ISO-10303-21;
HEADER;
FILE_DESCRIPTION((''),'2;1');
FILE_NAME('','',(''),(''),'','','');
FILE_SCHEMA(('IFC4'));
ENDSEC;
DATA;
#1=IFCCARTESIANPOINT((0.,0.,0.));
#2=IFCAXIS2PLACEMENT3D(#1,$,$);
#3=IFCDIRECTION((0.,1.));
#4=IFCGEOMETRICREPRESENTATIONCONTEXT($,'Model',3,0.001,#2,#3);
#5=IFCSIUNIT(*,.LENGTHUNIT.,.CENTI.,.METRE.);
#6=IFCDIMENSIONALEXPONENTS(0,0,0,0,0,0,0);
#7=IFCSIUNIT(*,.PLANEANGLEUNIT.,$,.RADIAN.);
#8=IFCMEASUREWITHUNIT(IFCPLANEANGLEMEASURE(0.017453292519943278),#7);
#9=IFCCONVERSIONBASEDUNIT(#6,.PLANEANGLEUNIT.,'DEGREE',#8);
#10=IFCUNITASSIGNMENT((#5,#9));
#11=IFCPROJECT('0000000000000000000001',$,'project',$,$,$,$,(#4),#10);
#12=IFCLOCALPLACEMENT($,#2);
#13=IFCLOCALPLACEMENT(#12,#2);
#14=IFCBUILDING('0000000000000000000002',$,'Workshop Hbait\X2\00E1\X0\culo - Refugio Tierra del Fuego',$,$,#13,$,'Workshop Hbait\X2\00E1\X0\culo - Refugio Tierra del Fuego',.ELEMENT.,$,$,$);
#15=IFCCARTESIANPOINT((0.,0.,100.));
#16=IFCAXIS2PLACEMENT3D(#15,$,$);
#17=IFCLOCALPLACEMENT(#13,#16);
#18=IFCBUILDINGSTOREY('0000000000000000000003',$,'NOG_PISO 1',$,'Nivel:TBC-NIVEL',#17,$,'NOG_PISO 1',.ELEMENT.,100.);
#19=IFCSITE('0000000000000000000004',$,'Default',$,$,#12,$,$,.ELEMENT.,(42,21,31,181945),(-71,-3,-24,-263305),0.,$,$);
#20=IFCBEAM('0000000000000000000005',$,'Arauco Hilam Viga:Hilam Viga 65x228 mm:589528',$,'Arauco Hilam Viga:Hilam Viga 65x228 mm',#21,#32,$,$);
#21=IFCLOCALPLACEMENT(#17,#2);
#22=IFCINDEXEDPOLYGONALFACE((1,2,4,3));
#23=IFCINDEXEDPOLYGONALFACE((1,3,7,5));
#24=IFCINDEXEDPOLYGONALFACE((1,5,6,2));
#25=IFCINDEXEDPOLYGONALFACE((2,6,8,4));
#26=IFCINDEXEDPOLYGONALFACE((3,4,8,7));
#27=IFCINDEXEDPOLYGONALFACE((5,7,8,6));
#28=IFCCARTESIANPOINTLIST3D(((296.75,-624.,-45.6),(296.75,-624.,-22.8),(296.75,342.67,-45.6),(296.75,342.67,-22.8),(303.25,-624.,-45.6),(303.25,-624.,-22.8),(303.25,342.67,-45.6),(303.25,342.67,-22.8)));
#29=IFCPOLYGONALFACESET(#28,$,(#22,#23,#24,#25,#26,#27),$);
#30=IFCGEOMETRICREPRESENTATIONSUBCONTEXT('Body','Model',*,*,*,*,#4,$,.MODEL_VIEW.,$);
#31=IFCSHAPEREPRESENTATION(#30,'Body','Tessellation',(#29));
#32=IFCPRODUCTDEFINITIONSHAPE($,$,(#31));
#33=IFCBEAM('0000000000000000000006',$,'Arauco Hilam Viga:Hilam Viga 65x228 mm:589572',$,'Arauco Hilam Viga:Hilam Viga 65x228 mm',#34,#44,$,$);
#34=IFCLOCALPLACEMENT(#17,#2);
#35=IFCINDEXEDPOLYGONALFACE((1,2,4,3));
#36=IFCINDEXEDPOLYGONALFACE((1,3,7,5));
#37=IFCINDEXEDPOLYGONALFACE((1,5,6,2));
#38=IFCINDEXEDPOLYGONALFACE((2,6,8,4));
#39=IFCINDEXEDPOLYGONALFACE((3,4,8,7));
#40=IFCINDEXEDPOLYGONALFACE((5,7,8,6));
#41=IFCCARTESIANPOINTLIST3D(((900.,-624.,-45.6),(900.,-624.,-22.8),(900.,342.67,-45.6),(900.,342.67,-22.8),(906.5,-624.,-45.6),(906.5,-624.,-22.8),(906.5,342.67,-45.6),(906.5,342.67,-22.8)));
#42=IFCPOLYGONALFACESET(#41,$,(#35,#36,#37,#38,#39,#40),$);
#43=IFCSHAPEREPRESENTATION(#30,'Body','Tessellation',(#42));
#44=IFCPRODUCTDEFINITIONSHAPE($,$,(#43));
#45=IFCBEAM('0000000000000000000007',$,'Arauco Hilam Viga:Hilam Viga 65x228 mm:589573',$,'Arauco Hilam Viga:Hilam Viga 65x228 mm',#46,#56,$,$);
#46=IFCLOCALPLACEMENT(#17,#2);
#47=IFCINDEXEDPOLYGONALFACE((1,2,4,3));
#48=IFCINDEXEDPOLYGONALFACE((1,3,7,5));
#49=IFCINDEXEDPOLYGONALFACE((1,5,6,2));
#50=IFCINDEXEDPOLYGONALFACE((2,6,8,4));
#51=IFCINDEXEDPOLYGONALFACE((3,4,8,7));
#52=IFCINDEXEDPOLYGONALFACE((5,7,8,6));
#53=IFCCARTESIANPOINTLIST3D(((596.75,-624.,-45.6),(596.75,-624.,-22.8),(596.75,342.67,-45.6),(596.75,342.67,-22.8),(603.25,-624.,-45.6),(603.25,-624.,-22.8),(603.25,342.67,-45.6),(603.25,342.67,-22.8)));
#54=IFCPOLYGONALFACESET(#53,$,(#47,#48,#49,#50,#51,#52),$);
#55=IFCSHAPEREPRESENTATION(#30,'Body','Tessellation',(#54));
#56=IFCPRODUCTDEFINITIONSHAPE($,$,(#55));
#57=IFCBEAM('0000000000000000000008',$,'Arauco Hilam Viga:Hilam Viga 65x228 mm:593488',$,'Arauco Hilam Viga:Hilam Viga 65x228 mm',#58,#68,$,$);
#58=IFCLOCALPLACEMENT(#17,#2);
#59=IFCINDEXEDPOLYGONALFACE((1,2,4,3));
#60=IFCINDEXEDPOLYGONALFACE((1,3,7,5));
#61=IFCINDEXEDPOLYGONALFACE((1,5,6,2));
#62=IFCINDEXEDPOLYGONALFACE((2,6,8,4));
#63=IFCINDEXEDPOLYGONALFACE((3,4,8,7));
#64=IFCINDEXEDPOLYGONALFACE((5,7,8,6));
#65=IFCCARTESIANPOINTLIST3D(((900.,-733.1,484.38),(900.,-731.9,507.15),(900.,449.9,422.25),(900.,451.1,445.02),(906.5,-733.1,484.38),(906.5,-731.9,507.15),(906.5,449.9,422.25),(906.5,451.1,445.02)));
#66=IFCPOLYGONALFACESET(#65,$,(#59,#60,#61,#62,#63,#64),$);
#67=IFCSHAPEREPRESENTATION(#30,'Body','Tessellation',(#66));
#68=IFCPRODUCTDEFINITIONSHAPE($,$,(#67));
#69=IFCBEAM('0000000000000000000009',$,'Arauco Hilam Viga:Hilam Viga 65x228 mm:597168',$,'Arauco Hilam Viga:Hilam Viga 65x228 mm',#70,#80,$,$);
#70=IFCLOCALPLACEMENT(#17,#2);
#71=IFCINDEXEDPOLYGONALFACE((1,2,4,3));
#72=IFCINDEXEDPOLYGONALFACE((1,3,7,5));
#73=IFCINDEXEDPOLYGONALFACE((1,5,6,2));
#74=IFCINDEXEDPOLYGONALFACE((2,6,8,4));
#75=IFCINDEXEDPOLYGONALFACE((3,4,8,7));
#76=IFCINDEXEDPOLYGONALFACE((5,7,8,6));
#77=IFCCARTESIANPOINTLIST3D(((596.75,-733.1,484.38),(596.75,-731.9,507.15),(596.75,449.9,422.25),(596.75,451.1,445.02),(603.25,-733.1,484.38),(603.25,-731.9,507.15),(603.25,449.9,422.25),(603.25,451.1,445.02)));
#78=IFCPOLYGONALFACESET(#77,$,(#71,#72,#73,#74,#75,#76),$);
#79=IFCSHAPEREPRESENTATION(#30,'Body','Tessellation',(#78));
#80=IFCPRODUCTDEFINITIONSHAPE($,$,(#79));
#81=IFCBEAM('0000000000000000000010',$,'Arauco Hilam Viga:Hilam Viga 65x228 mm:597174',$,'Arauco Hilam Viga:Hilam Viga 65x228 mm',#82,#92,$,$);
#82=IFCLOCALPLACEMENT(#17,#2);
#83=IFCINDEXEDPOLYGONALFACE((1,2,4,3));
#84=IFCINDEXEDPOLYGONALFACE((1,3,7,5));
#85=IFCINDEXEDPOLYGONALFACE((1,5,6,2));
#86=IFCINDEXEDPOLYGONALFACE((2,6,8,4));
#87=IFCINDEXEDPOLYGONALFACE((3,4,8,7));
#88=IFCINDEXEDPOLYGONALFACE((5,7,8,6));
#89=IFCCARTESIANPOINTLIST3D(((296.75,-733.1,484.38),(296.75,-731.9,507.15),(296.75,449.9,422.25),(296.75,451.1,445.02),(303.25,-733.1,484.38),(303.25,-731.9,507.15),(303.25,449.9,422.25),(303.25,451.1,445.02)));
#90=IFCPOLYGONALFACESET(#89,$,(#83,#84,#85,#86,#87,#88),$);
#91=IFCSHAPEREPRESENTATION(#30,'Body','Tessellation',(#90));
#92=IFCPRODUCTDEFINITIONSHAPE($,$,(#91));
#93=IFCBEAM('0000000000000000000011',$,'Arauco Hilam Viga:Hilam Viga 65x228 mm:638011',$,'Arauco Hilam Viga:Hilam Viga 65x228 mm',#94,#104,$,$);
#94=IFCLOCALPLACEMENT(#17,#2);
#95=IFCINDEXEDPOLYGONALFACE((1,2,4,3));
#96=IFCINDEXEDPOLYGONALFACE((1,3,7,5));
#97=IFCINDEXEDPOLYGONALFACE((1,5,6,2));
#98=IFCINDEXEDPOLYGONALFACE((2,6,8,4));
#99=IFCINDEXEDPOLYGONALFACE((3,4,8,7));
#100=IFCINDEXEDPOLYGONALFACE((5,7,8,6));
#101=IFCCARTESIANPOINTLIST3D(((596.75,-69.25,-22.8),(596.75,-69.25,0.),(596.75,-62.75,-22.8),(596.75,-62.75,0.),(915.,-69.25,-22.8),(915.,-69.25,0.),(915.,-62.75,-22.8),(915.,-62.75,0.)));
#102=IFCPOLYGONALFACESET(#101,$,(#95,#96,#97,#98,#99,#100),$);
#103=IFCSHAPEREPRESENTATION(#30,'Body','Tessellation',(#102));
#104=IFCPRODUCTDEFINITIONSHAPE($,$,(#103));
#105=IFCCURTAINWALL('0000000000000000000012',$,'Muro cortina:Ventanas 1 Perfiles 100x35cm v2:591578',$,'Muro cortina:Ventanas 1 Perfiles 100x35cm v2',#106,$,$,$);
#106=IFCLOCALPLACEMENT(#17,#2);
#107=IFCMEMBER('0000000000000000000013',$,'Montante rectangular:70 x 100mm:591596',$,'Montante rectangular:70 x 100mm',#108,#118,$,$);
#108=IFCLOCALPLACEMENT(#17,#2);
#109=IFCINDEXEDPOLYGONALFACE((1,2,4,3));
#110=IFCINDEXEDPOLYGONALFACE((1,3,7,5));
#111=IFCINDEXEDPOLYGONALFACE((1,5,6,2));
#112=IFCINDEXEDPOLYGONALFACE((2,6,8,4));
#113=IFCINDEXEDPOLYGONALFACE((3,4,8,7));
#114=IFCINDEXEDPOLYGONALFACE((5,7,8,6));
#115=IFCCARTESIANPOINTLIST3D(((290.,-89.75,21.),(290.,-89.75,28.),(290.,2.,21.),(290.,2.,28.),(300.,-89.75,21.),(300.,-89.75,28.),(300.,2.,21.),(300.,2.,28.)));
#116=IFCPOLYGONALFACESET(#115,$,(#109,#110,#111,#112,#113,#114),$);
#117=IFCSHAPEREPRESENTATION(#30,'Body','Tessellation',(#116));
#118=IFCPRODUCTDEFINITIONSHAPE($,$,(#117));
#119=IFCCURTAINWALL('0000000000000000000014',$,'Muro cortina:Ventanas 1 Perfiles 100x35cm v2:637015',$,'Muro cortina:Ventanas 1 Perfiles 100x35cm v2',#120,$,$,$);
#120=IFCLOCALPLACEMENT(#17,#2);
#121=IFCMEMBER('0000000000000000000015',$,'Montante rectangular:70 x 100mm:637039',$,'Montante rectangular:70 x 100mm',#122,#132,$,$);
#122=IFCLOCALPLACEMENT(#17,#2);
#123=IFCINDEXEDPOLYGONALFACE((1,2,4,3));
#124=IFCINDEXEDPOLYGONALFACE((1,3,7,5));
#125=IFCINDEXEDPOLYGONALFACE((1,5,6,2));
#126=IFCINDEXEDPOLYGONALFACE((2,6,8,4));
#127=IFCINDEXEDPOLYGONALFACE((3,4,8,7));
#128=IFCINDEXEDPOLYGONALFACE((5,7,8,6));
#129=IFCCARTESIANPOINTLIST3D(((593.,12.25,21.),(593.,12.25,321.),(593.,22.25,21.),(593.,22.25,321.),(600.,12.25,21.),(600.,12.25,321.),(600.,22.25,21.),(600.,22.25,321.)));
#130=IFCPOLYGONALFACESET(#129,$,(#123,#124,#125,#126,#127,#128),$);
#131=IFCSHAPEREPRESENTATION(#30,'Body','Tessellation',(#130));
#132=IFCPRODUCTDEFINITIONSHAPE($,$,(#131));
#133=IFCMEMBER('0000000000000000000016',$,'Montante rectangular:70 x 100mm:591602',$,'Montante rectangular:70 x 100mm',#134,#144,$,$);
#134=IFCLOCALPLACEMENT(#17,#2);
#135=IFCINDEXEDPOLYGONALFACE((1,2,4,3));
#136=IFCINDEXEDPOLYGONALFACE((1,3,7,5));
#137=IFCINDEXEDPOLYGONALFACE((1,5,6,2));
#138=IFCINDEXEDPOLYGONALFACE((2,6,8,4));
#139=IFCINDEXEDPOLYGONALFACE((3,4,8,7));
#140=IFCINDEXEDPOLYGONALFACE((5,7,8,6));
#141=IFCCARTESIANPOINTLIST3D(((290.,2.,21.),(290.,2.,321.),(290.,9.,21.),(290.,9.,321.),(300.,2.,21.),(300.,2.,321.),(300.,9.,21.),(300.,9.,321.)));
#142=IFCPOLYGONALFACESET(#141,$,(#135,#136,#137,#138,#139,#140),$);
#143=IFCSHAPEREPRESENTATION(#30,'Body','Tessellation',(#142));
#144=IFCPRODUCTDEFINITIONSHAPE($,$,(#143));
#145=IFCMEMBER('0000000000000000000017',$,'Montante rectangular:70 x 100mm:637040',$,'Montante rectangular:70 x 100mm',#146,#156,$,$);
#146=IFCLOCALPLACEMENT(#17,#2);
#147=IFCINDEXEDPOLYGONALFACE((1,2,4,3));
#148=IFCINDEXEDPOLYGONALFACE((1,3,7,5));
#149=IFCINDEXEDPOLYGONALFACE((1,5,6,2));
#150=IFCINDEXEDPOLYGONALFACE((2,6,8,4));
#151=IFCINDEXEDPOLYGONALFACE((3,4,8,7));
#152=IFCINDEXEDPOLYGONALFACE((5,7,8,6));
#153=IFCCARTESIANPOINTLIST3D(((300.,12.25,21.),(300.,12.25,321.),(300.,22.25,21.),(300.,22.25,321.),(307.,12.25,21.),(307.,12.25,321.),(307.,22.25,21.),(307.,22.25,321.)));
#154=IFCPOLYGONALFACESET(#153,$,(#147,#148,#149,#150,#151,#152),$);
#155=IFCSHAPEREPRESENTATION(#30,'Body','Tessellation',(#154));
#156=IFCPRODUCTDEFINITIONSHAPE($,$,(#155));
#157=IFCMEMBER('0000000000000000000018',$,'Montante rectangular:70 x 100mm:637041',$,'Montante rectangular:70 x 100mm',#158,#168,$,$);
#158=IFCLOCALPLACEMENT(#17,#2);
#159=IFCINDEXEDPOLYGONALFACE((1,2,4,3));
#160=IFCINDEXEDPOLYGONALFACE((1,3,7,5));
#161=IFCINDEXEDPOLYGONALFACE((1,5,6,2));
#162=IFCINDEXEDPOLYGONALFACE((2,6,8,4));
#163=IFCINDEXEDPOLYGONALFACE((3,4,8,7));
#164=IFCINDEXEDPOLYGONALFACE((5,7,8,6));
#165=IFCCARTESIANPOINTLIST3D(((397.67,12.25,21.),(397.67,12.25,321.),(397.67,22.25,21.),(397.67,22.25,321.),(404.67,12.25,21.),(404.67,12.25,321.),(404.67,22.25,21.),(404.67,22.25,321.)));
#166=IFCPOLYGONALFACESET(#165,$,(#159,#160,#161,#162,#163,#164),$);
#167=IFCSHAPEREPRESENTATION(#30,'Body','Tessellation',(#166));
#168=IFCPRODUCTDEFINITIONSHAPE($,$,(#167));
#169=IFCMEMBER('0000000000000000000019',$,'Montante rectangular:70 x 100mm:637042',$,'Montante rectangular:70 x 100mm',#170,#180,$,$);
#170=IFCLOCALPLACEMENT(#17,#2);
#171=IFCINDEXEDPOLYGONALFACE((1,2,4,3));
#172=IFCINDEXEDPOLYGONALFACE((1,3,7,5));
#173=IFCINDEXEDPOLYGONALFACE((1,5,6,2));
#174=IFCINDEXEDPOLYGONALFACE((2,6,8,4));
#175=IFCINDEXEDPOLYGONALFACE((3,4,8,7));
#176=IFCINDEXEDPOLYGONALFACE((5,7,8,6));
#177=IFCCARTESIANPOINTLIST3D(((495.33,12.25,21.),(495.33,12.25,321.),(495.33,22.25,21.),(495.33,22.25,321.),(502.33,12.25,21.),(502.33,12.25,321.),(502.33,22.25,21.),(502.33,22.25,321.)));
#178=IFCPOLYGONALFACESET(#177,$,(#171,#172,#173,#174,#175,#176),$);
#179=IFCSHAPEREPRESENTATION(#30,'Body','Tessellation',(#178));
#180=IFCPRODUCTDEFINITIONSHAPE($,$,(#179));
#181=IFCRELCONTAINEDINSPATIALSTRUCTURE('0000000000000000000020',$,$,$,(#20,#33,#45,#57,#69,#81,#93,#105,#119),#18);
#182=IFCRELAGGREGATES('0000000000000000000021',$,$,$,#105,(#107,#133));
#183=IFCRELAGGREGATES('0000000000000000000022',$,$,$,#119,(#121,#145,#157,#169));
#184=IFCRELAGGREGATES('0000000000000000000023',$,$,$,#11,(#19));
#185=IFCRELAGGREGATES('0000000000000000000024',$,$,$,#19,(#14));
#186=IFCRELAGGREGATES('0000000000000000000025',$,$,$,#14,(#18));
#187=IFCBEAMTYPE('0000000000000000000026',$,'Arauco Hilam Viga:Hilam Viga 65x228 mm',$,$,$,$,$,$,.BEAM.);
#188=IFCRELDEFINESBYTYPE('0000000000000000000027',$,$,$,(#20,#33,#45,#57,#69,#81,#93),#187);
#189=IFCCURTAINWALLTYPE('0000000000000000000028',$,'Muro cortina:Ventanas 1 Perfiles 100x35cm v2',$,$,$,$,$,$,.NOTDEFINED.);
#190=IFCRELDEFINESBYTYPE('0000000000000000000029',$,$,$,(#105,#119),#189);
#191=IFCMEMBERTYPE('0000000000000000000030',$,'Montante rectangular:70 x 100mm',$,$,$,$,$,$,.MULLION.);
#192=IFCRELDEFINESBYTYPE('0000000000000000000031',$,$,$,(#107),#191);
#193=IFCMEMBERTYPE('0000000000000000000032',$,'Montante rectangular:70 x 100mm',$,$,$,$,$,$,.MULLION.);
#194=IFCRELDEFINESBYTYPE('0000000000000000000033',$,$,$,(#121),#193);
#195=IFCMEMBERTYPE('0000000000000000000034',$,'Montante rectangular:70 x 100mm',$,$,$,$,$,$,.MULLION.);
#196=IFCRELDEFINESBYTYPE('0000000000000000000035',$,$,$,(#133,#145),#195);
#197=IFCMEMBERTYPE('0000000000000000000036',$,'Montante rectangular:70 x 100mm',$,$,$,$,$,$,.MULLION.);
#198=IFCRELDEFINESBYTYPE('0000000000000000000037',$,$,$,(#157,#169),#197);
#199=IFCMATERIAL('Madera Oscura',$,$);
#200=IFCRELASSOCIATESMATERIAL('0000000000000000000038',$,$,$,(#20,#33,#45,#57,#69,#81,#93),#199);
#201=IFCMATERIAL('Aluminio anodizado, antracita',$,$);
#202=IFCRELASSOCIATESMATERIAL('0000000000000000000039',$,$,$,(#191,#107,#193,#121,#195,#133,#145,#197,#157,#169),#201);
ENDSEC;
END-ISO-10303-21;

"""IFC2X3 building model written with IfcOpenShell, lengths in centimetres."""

from ifc_helpers import new_model, entity, si_unit, converted_unit, direction, frame, frame_2d, origin, origin_2d_with_axis, place, context, subcontext, project, spatial, rectangle, extrude, source, transform, mapped, material, type_object, type_shapes, element, aggregate, save


model = new_model("IFC2X3")

# Units and contexts
model_context = context("Model", 3, precision=0.001, world=origin(), true_north=direction((0.0, 1.0)))
body_context = subcontext(model_context, "Body", "Model", "MODEL_VIEW")
ifc_project = project(units=[si_unit("LENGTHUNIT", "METRE", prefix="CENTI"), converted_unit("PLANEANGLEUNIT", "DEGREE", entity("IfcPlaneAngleMeasure", 0.017453292519943278), si_unit("PLANEANGLEUNIT", "RADIAN"), dimensions=[0, 0, 0, 0, 0, 0, 0])], contexts=[model_context])

# Site, building, storey
site_placement = place(None, origin())
site = spatial("IfcSite", under=ifc_project, at=site_placement, Name="Default", CompositionType="ELEMENT", RefLatitude=(42, 21, 31, 181945), RefLongitude=(-71, -3, -24, -263305), RefElevation=0.0)
building_placement = place(site_placement, origin())
building = spatial("IfcBuilding", under=site, at=building_placement, Name="Workshop Hbaitáculo - Refugio Tierra del Fuego", LongName="Workshop Hbaitáculo - Refugio Tierra del Fuego", CompositionType="ELEMENT")
storey_placement = place(building_placement, frame((0.0, 0.0, 100.0)))
storey = spatial("IfcBuildingStorey", under=building, at=storey_placement, Name="NOG_PISO 1", ObjectType="Nivel:TBC-NIVEL", LongName="NOG_PISO 1", CompositionType="ELEMENT", Elevation=100.0)

# Beams
ifc_material_1 = material(Name="Madera Oscura")
beam_type = type_object("IfcBeamType", Name="Arauco Hilam Viga:Hilam Viga 65x228 mm", PredefinedType="BEAM")
beam_1_placement = place(storey_placement, frame((300.0, 318.11, -22.8), z_axis=(0.0, 0.0, 1.0), x_axis=(0.0, -1.0, 0.0)))
element("IfcBeam", 1, at=beam_1_placement, inside=storey, type_object=beam_type, material=ifc_material_1, Name="Arauco Hilam Viga:Hilam Viga 65x228 mm:589528", ObjectType="Arauco Hilam Viga:Hilam Viga 65x228 mm", context=body_context, shape_type="SweptSolid", body=[
    extrude(rectangle(XDim=22.8, YDim=6.5, at=frame_2d((0.0, 0.0), x_axis=(1.0, 0.0))), frame((-24.56, 0.0, -11.4), z_axis=(1.0, 0.0, 0.0), x_axis=(0.0, 0.0, -1.0)), (0.0, 0.0, 1.0), 966.67),
])
for number, where, z_axis, x_axis, name in (
    (2, (903.25, 318.11, -22.8), (0.0, 0.0, 1.0), (0.0, -1.0, 0.0), "Arauco Hilam Viga:Hilam Viga 65x228 mm:589572"),
    (3, (600.0, 318.11, -22.8), (0.0, 0.0, 1.0), (0.0, -1.0, 0.0), "Arauco Hilam Viga:Hilam Viga 65x228 mm:589573"),
):
    element("IfcBeam", number, at=place(storey_placement, frame(where, z_axis=z_axis, x_axis=x_axis)), inside=storey, type_object=beam_type, material=ifc_material_1, Name=name, ObjectType="Arauco Hilam Viga:Hilam Viga 65x228 mm", context=body_context, shape_type="SweptSolid", body=[
        extrude(rectangle(XDim=22.8, YDim=6.5, at=frame_2d((0.0, 0.0), x_axis=(1.0, 0.0))), frame((-24.56, 0.0, -11.4), z_axis=(1.0, 0.0, 0.0), x_axis=(0.0, 0.0, -1.0)), (0.0, 0.0, 1.0), 966.67),
    ])
beam_2_placement = place(storey_placement, frame((903.25, 318.11, 452.0), z_axis=(0.0, 0.052449, 0.998624), x_axis=(0.0, -0.998624, 0.052449)))
element("IfcBeam", 4, at=beam_2_placement, inside=storey, type_object=beam_type, material=ifc_material_1, Name="Arauco Hilam Viga:Hilam Viga 65x228 mm:593488", ObjectType="Arauco Hilam Viga:Hilam Viga 65x228 mm", context=body_context, shape_type="SweptSolid", body=[
    extrude(rectangle(XDim=22.8, YDim=6.5, at=origin_2d_with_axis()), frame((-133.18, 0.0, -11.4), z_axis=(1.0, 0.0, 0.0), x_axis=(0.0, 0.0, -1.0)), (0.0, 0.0, 1.0), 1184.63),
])
beam_3_placement = place(storey_placement, frame((600.0, 318.11, 452.0), z_axis=(0.0, 0.052449, 0.998624), x_axis=(0.0, -0.998624, 0.052449)))
element("IfcBeam", 5, at=beam_3_placement, inside=storey, type_object=beam_type, material=ifc_material_1, Name="Arauco Hilam Viga:Hilam Viga 65x228 mm:597168", ObjectType="Arauco Hilam Viga:Hilam Viga 65x228 mm", context=body_context, shape_type="SweptSolid", body=[
    extrude(rectangle(XDim=22.8, YDim=6.5, at=origin_2d_with_axis()), frame((-133.18, 0.0, -11.4), z_axis=(1.0, 0.0, 0.0), x_axis=(0.0, 0.0, -1.0)), (0.0, 0.0, 1.0), 1184.63),
])
beam_4_placement = place(storey_placement, frame((300.0, 318.11, 452.0), z_axis=(0.0, 0.052449, 0.998624), x_axis=(0.0, -0.998624, 0.052449)))
element("IfcBeam", 6, at=beam_4_placement, inside=storey, type_object=beam_type, material=ifc_material_1, Name="Arauco Hilam Viga:Hilam Viga 65x228 mm:597174", ObjectType="Arauco Hilam Viga:Hilam Viga 65x228 mm", context=body_context, shape_type="SweptSolid", body=[
    extrude(rectangle(XDim=22.8, YDim=6.5, at=frame_2d((0.0, 0.0), x_axis=(1.0, 0.0))), frame((-133.18, 0.0, -11.4), z_axis=(1.0, 0.0, 0.0), x_axis=(0.0, 0.0, -1.0)), (0.0, 0.0, 1.0), 1184.63),
])
beam_5_placement = place(storey_placement, frame((596.75, -66.0, 0.0)))
element("IfcBeam", 7, at=beam_5_placement, inside=storey, type_object=beam_type, material=ifc_material_1, Name="Arauco Hilam Viga:Hilam Viga 65x228 mm:638011", ObjectType="Arauco Hilam Viga:Hilam Viga 65x228 mm", context=body_context, shape_type="SweptSolid", body=[
    extrude(rectangle(XDim=22.8, YDim=6.5, at=frame_2d((0.0, 0.0), x_axis=(1.0, 0.0))), frame((0.0, 0.0, -11.4), z_axis=(1.0, 0.0, 0.0), x_axis=(0.0, 0.0, -1.0)), (0.0, 0.0, 1.0), 318.25),
])

# Curtain walls, members
curtain_wall_type = type_object("IfcCurtainWallType", Name="Muro cortina:Ventanas 1 Perfiles 100x35cm v2", PredefinedType="NOTDEFINED")
curtain_wall_1_placement = place(storey_placement, frame((0.0, 0.0, -100.0)))
curtain_wall_1 = element("IfcCurtainWall", 8, at=curtain_wall_1_placement, inside=storey, type_object=curtain_wall_type, Name="Muro cortina:Ventanas 1 Perfiles 100x35cm v2:591578", ObjectType="Muro cortina:Ventanas 1 Perfiles 100x35cm v2")
ifc_material_2 = material(Name="Aluminio anodizado, antracita")
member_type_1 = type_object("IfcMemberType", Name="Montante rectangular:70 x 100mm", PredefinedType="MULLION", material=ifc_material_2)
shared_shape_1 = source(origin(), body_context, "Body", "SweptSolid", [
    extrude(rectangle(XDim=7.0, YDim=10.0, at=origin_2d_with_axis()), frame((-3.5, 0.0, -91.75), z_axis=(0.0, 0.0, 1.0), x_axis=(-1.0, 0.0, 0.0)), (0.0, 0.0, 1.0), 91.75),
])
type_shapes(member_type_1, [shared_shape_1])
member_1_placement = place(curtain_wall_1_placement, frame((295.0, 2.0, 121.0), z_axis=(0.0, 1.0, 0.0), x_axis=(0.0, 0.0, -1.0)))
member_1 = element("IfcMember", 9, at=member_1_placement, type_object=member_type_1, material=ifc_material_2, Name="Montante rectangular:70 x 100mm:591596", ObjectType="Montante rectangular:70 x 100mm", context=body_context, shape_type="MappedRepresentation", body=[
    mapped(shared_shape_1, transform((0.0, 0.0, 0.0), scale=1.0)),
])
curtain_wall_2_placement = place(storey_placement, frame((0.0, 0.0, -100.0)))
curtain_wall_2 = element("IfcCurtainWall", 10, at=curtain_wall_2_placement, inside=storey, type_object=curtain_wall_type, Name="Muro cortina:Ventanas 1 Perfiles 100x35cm v2:637015", ObjectType="Muro cortina:Ventanas 1 Perfiles 100x35cm v2")
member_type_2 = type_object("IfcMemberType", Name="Montante rectangular:70 x 100mm", PredefinedType="MULLION", material=ifc_material_2)
shared_shape_2 = source(origin(), body_context, "Body", "SweptSolid", [
    extrude(rectangle(XDim=7.0, YDim=10.0, at=origin_2d_with_axis()), frame((-3.5, 0.0, -300.0), z_axis=(0.0, 0.0, 1.0), x_axis=(-1.0, 0.0, 0.0)), (0.0, 0.0, 1.0), 300.0),
])
type_shapes(member_type_2, [shared_shape_2])
member_2_placement = place(curtain_wall_2_placement, frame((600.0, 17.25, 121.0), z_axis=(0.0, 0.0, -1.0), x_axis=(1.0, 0.0, 0.0)))
member_2 = element("IfcMember", 11, at=member_2_placement, type_object=member_type_2, material=ifc_material_2, Name="Montante rectangular:70 x 100mm:637039", ObjectType="Montante rectangular:70 x 100mm", context=body_context, shape_type="MappedRepresentation", body=[
    mapped(shared_shape_2, transform((0.0, 0.0, 0.0), scale=1.0)),
])

# Members
member_type_3 = type_object("IfcMemberType", Name="Montante rectangular:70 x 100mm", PredefinedType="MULLION", material=ifc_material_2)
shared_shape_3 = source(origin(), body_context, "Body", "SweptSolid", [
    extrude(rectangle(XDim=7.0, YDim=10.0, at=origin_2d_with_axis()), frame((-3.5, 0.0, -300.0), z_axis=(0.0, 0.0, 1.0), x_axis=(-1.0, 0.0, 0.0)), (0.0, 0.0, 1.0), 300.0),
])
type_shapes(member_type_3, [shared_shape_3])
member_3_placement = place(curtain_wall_1_placement, frame((295.0, 9.0, 421.0), z_axis=(0.0, 0.0, 1.0), x_axis=(0.0, 1.0, 0.0)))
member_3 = element("IfcMember", 12, at=member_3_placement, type_object=member_type_3, material=ifc_material_2, Name="Montante rectangular:70 x 100mm:591602", ObjectType="Montante rectangular:70 x 100mm", context=body_context, shape_type="MappedRepresentation", body=[
    mapped(shared_shape_3, transform((0.0, 0.0, 0.0), scale=1.0)),
])
member_4_placement = place(curtain_wall_2_placement, frame((300.0, 17.25, 421.0), z_axis=(0.0, 0.0, 1.0), x_axis=(-1.0, 0.0, 0.0)))
member_4 = element("IfcMember", 13, at=member_4_placement, type_object=member_type_3, material=ifc_material_2, Name="Montante rectangular:70 x 100mm:637040", ObjectType="Montante rectangular:70 x 100mm", context=body_context, shape_type="MappedRepresentation", body=[
    mapped(shared_shape_3, transform((0.0, 0.0, 0.0), scale=1.0)),
])
member_type_4 = type_object("IfcMemberType", Name="Montante rectangular:70 x 100mm", PredefinedType="MULLION", material=ifc_material_2)
shared_shape_4 = source(origin(), body_context, "Body", "SweptSolid", [
    extrude(rectangle(XDim=7.0, YDim=10.0, at=frame_2d((0.0, 0.0), x_axis=(1.0, 0.0))), frame((0.0, 0.0, -300.0), z_axis=(0.0, 0.0, 1.0), x_axis=(-1.0, 0.0, 0.0)), (0.0, 0.0, 1.0), 300.0),
])
type_shapes(member_type_4, [shared_shape_4])
member_5_placement = place(curtain_wall_2_placement, frame((401.17, 17.25, 121.0), z_axis=(0.0, 0.0, -1.0), x_axis=(1.0, 0.0, 0.0)))
member_5 = element("IfcMember", 14, at=member_5_placement, type_object=member_type_4, material=ifc_material_2, Name="Montante rectangular:70 x 100mm:637041", ObjectType="Montante rectangular:70 x 100mm", context=body_context, shape_type="MappedRepresentation", body=[
    mapped(shared_shape_4, transform((0.0, 0.0, 0.0), scale=1.0)),
])
member_6_placement = place(curtain_wall_2_placement, frame((498.83, 17.25, 121.0), z_axis=(0.0, 0.0, -1.0), x_axis=(1.0, 0.0, 0.0)))
member_6 = element("IfcMember", 15, at=member_6_placement, type_object=member_type_4, material=ifc_material_2, Name="Montante rectangular:70 x 100mm:637042", ObjectType="Montante rectangular:70 x 100mm", context=body_context, shape_type="MappedRepresentation", body=[
    mapped(shared_shape_4, transform((0.0, 0.0, 0.0), scale=1.0)),
])

aggregate(curtain_wall_1, [member_1, member_3])
aggregate(curtain_wall_2, [member_2, member_4, member_5, member_6])

save(model, "model.ifc")
